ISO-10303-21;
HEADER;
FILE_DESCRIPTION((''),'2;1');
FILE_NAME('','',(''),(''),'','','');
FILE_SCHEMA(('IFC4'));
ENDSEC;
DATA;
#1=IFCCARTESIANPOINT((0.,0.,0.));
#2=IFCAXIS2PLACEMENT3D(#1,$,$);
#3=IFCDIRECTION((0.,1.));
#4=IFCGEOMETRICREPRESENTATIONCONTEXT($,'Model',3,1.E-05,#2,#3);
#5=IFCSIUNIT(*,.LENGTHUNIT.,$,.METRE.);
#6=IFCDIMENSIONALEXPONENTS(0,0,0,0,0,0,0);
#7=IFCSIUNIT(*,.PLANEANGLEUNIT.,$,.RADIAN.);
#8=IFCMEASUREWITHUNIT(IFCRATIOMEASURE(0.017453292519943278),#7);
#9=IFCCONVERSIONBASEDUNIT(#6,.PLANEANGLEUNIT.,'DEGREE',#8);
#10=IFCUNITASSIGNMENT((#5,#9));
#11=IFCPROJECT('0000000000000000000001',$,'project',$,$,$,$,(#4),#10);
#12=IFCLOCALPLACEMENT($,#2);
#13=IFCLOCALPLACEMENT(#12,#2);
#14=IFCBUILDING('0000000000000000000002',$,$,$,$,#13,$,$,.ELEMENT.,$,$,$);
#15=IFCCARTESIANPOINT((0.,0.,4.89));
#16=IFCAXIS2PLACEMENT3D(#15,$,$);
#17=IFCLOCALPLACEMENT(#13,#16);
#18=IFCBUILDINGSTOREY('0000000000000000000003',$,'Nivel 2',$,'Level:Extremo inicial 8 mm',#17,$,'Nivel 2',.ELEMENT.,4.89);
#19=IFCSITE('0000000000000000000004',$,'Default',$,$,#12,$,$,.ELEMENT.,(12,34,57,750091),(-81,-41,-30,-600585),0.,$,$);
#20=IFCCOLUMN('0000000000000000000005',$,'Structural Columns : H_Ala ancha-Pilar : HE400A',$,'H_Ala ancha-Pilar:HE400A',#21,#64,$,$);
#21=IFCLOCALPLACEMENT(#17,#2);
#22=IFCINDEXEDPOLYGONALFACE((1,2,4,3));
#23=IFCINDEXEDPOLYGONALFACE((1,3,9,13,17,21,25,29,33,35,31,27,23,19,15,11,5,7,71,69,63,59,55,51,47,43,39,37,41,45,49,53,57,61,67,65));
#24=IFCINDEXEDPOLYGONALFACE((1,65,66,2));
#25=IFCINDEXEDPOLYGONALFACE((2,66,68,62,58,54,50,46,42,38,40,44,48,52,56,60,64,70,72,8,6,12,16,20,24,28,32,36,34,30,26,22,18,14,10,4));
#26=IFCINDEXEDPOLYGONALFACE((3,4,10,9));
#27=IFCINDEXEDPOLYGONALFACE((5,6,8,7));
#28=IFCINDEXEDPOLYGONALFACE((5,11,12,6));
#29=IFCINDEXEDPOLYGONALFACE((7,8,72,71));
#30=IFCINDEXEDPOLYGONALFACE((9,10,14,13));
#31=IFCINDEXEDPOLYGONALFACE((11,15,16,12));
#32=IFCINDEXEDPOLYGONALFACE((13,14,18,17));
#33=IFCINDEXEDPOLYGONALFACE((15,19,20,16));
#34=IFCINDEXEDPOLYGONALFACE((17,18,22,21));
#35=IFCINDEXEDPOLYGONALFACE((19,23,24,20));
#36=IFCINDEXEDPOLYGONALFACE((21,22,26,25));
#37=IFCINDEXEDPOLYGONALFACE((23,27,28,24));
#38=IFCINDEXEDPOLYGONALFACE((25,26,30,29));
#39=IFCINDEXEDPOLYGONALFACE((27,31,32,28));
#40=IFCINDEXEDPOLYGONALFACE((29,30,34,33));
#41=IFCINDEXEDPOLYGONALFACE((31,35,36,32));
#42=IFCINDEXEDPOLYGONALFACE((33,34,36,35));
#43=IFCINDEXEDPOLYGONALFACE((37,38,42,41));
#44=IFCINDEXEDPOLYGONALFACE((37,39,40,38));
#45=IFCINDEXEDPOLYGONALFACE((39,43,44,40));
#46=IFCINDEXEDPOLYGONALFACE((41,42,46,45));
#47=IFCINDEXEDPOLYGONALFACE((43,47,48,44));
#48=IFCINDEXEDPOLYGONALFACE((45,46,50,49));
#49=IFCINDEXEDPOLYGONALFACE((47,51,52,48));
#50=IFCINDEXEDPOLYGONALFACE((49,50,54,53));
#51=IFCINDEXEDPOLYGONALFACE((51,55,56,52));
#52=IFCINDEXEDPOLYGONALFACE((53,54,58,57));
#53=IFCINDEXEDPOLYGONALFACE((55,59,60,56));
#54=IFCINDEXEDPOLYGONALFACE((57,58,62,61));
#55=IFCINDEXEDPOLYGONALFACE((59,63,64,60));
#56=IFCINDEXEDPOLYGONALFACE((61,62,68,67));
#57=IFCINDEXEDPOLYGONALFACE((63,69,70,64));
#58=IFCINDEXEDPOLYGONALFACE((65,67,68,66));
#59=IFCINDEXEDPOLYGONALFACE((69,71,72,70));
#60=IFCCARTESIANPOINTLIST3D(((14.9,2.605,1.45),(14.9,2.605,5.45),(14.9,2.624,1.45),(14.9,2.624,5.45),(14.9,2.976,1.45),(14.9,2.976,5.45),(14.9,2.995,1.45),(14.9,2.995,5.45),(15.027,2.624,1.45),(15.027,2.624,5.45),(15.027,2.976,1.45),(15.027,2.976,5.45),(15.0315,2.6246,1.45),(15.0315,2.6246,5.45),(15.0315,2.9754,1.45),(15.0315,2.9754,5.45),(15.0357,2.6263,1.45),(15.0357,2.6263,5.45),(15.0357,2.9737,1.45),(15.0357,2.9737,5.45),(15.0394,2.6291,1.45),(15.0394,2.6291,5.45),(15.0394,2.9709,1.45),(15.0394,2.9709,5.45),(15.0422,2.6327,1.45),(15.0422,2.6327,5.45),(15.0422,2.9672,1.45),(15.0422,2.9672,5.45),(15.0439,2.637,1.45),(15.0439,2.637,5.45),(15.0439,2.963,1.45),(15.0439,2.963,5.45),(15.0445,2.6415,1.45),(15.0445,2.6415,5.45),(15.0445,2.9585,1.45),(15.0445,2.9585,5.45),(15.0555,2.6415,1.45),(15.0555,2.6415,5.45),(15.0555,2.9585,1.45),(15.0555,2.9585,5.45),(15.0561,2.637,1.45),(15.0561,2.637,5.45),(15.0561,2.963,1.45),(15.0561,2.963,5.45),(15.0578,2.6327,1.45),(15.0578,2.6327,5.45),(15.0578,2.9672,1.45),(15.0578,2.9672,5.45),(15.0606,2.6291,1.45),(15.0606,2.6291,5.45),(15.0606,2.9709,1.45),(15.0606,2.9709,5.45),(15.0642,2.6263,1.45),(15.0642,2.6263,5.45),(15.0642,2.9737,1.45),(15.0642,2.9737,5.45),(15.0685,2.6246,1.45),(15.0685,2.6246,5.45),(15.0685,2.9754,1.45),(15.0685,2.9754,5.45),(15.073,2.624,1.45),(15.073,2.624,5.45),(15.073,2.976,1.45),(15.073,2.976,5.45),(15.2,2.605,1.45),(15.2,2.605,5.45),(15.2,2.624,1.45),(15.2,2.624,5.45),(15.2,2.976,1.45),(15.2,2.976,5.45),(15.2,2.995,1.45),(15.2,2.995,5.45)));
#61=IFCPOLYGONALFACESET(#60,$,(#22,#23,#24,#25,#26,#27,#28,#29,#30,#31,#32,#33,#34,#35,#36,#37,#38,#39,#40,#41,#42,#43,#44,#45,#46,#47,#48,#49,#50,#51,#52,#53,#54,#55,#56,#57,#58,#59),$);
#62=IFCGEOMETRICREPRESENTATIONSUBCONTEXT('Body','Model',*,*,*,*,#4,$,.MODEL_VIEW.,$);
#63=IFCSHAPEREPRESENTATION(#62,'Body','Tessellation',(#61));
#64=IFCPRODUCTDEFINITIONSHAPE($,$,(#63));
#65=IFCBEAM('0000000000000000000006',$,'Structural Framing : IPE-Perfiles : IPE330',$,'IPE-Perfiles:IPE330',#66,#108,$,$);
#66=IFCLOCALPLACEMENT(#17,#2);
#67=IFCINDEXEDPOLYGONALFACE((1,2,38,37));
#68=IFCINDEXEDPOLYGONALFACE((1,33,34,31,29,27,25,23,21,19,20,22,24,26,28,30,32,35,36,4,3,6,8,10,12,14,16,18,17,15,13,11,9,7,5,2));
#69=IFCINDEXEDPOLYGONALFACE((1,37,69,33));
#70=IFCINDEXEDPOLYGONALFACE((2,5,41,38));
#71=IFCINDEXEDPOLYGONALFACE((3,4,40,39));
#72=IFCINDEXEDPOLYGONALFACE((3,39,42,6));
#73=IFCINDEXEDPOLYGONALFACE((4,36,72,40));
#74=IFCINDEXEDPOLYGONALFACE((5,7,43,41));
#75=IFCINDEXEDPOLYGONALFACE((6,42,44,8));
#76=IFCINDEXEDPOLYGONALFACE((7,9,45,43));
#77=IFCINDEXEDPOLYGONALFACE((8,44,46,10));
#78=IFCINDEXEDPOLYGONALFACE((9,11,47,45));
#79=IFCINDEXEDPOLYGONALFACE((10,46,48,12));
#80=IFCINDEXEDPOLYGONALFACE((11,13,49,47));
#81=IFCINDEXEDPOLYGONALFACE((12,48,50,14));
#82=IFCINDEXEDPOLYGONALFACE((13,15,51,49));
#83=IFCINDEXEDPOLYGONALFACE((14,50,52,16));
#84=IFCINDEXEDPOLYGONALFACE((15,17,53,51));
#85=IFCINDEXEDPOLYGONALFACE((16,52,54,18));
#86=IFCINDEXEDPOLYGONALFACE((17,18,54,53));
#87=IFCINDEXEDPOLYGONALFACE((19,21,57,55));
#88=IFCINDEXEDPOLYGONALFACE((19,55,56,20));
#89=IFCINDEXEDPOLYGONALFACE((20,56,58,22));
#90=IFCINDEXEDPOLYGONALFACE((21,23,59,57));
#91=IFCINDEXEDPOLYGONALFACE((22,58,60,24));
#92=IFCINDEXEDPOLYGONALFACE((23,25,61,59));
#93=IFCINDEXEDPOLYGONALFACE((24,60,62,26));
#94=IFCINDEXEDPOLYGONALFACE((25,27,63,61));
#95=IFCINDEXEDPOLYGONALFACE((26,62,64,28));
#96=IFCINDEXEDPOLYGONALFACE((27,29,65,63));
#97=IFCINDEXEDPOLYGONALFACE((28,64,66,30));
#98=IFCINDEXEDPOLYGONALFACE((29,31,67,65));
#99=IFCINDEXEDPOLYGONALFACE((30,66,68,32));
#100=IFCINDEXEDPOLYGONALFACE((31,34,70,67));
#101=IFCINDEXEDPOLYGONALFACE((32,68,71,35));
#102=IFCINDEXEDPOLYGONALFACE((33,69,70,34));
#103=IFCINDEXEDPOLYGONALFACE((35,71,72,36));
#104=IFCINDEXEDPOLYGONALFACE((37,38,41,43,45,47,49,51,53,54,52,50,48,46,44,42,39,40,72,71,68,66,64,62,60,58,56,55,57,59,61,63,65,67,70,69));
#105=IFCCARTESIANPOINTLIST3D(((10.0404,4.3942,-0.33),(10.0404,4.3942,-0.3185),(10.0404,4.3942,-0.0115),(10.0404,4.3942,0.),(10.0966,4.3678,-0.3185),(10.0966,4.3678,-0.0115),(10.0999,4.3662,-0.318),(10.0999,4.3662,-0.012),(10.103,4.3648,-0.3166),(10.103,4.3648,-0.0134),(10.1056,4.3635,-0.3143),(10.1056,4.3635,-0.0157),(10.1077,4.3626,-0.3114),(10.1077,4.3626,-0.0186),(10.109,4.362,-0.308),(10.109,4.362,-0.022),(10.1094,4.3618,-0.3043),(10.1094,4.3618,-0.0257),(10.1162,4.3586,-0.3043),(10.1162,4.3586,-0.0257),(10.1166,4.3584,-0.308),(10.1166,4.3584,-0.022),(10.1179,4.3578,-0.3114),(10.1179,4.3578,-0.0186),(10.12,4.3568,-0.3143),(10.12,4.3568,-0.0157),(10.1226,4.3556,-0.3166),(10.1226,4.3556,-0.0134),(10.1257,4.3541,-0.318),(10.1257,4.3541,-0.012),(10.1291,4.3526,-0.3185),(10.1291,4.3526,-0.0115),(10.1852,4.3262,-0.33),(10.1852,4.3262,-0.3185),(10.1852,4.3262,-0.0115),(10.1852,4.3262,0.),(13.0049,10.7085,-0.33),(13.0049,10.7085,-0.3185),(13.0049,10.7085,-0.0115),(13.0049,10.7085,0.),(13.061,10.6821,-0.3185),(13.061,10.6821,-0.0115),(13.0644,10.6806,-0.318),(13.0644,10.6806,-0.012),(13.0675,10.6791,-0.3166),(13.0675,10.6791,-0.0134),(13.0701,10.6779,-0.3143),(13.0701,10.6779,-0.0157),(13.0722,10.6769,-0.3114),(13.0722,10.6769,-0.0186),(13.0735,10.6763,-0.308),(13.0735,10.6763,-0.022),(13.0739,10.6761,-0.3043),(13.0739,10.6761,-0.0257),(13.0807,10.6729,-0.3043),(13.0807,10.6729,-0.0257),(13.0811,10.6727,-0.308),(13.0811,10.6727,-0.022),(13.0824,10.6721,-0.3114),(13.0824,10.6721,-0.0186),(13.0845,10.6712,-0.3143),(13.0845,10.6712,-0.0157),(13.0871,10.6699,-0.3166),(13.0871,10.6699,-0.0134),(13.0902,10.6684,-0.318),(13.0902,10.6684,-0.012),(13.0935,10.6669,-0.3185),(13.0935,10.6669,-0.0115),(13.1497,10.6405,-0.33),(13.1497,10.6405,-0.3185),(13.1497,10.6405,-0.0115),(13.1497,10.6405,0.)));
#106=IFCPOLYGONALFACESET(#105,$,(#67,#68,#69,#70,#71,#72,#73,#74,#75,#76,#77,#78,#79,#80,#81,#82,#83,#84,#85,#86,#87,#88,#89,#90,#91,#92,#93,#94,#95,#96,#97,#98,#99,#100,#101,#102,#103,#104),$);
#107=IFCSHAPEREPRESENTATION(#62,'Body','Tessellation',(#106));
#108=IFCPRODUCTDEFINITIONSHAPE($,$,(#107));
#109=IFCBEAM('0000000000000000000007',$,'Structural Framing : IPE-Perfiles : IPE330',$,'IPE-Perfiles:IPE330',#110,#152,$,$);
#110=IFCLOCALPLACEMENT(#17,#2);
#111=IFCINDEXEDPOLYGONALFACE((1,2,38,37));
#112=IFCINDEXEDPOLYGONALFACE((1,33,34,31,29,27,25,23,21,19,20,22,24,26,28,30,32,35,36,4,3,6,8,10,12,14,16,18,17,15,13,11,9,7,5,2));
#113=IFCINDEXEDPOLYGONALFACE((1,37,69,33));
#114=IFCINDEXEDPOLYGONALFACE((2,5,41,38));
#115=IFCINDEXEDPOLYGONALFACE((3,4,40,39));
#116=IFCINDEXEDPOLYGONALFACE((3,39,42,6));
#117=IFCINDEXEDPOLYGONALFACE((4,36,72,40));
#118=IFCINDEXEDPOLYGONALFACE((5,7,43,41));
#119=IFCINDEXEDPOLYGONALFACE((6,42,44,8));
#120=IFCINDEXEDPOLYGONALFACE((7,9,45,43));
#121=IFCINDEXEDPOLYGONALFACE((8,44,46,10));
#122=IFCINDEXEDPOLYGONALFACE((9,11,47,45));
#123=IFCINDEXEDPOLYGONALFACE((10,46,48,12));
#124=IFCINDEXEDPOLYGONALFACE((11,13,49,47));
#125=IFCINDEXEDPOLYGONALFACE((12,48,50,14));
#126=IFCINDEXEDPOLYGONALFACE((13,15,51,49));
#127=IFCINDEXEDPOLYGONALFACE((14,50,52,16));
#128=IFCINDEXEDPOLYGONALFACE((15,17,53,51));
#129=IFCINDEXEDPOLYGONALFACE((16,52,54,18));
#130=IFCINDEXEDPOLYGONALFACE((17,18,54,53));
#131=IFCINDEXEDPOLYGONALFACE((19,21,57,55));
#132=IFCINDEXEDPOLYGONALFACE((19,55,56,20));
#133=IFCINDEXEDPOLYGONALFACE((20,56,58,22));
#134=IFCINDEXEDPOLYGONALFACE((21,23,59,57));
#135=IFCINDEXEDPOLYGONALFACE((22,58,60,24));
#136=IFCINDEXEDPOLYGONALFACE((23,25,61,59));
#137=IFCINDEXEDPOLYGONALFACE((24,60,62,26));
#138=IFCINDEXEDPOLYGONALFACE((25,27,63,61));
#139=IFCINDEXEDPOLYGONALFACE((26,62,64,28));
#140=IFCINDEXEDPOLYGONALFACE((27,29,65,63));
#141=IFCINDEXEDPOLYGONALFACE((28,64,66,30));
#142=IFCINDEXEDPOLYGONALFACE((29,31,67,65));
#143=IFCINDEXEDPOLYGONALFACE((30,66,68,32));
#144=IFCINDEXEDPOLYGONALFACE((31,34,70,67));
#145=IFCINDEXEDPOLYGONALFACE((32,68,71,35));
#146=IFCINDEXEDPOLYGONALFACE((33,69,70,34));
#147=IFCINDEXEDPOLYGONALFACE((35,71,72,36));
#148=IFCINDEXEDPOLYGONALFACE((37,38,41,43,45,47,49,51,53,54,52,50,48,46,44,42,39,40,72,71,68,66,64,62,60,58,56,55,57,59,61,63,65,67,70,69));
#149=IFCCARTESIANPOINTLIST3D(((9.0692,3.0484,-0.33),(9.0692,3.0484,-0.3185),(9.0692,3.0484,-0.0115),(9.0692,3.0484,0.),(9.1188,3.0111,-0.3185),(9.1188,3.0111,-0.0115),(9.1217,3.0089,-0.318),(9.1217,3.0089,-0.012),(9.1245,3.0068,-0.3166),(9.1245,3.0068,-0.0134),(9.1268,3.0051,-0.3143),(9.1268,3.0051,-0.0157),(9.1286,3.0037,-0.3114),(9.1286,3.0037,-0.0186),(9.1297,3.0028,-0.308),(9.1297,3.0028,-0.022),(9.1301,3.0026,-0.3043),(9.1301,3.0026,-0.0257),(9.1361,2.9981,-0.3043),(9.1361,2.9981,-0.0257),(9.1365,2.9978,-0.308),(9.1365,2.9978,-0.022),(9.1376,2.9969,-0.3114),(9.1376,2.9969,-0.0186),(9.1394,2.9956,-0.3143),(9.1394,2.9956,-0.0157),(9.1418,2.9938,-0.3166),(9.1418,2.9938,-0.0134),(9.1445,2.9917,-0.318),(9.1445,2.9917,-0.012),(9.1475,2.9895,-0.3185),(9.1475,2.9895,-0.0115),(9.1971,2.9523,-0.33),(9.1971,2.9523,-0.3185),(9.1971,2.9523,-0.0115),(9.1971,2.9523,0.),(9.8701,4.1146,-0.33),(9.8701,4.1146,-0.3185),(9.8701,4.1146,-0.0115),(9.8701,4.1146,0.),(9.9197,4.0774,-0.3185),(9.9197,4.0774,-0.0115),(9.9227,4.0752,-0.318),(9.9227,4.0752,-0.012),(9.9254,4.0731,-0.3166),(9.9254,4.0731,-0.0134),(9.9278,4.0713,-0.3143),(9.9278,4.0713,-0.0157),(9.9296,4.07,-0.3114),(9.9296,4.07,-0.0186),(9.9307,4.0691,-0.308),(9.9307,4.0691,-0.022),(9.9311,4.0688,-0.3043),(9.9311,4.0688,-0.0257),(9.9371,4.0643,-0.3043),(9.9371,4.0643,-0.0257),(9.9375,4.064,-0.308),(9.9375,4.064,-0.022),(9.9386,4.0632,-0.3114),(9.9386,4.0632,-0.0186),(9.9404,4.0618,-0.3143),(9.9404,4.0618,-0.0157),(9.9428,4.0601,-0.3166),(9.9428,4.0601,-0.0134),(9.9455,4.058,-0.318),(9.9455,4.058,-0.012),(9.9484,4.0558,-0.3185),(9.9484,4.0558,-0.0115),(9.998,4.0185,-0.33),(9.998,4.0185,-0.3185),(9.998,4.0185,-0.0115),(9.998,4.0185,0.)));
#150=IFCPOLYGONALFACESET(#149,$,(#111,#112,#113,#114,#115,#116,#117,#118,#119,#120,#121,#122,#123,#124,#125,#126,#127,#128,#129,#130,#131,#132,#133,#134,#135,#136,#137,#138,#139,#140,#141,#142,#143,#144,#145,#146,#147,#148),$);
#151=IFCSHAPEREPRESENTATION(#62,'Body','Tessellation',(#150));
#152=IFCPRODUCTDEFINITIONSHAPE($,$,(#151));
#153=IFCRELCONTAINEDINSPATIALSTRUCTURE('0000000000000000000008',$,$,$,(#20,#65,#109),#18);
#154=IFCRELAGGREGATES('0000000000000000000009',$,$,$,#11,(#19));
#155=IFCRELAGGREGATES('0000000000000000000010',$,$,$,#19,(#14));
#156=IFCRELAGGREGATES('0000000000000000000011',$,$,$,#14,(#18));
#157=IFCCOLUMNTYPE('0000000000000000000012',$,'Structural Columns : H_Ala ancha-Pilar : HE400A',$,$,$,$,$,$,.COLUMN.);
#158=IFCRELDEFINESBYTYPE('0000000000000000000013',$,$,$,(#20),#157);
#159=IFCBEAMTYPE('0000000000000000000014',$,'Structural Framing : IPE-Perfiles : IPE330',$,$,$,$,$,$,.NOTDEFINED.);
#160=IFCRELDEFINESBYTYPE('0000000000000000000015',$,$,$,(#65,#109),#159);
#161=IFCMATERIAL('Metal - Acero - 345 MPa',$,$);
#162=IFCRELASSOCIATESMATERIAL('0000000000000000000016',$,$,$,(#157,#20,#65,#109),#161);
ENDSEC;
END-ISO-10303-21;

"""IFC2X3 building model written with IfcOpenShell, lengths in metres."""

from ifc_helpers import new_model, entity, si_unit, converted_unit, direction, frame, frame_2d, origin, place, context, subcontext, project, spatial, polyline, circle_curve, parameter, trimmed, segment, composite_curve, i_section, outline, extrude, source, transform, mapped, material, type_object, type_shapes, element, save


model = new_model("IFC2X3")

# Units and contexts
model_context = context("Model", 3, precision=1e-05, world=origin(), true_north=direction((0.0, 1.0)))
body_context = subcontext(model_context, "Body", "Model", "MODEL_VIEW")
ifc_project = project(units=[si_unit("LENGTHUNIT", "METRE"), converted_unit("PLANEANGLEUNIT", "DEGREE", entity("IfcRatioMeasure", 0.017453292519943278), si_unit("PLANEANGLEUNIT", "RADIAN"), dimensions=[0, 0, 0, 0, 0, 0, 0])], contexts=[model_context])

# Site, building, storey
site_placement = place(None, origin())
site = spatial("IfcSite", under=ifc_project, at=site_placement, Name="Default", CompositionType="ELEMENT", RefLatitude=(12, 34, 57, 750091), RefLongitude=(-81, -41, -30, -600585), RefElevation=0.0)
building_placement = place(site_placement, origin())
building = spatial("IfcBuilding", under=site, at=building_placement, CompositionType="ELEMENT")
storey_placement = place(building_placement, frame((0.0, 0.0, 4.89)))
storey = spatial("IfcBuildingStorey", under=building, at=storey_placement, Name="Nivel 2", ObjectType="Level:Extremo inicial 8 mm", LongName="Nivel 2", CompositionType="ELEMENT", Elevation=4.89)

# Column
ifc_material_1 = material(Name="Metal - Acero - 345 MPa")
column_type_1 = type_object("IfcColumnType", Name="Structural Columns : H_Ala ancha-Pilar : HE400A", PredefinedType="COLUMN", material=ifc_material_1)
shared_shape_1 = source(origin(), body_context, "Body", "SweptSolid", [
    extrude(outline(composite_curve([segment(polyline([(0.176, -0.15), (0.195, -0.15)]), True, "CONTINUOUS"), segment(polyline([(0.195, -0.15), (0.195, 0.15)]), True, "CONTINUOUS"), segment(polyline([(0.195, 0.15), (0.176, 0.15)]), True, "CONTINUOUS"), segment(polyline([(0.176, 0.15), (0.176, 0.023)]), True, "CONTINUOUS"), segment(trimmed(circle_curve(frame_2d((0.1585, 0.023), x_axis=(1.0, 0.0)), 0.0175), [parameter(270.0)], [parameter(0.0)], True, "PARAMETER"), False, "CONTINUOUS"), segment(polyline([(0.1585, 0.0055), (-0.1585, 0.0055)]), True, "CONTINUOUS"), segment(trimmed(circle_curve(frame_2d((-0.1585, 0.023), x_axis=(0.0, -1.0)), 0.0175), [parameter(270.0)], [parameter(0.0)], True, "PARAMETER"), False, "CONTINUOUS"), segment(polyline([(-0.176, 0.023), (-0.176, 0.15)]), True, "CONTINUOUS"), segment(polyline([(-0.176, 0.15), (-0.195, 0.15)]), True, "CONTINUOUS"), segment(polyline([(-0.195, 0.15), (-0.195, -0.15)]), True, "CONTINUOUS"), segment(polyline([(-0.195, -0.15), (-0.176, -0.15)]), True, "CONTINUOUS"), segment(polyline([(-0.176, -0.15), (-0.176, -0.023)]), True, "CONTINUOUS"), segment(trimmed(circle_curve(frame_2d((-0.1585, -0.023), x_axis=(-1.0, 0.0)), 0.0175), [parameter(270.0)], [parameter(0.0)], True, "PARAMETER"), False, "CONTINUOUS"), segment(polyline([(-0.1585, -0.0055), (0.1585, -0.0055)]), True, "CONTINUOUS"), segment(trimmed(circle_curve(frame_2d((0.1585, -0.023), x_axis=(0.0, 1.0)), 0.0175), [parameter(270.0)], [parameter(0.0)], True, "PARAMETER"), False, "CONTINUOUS"), segment(polyline([(0.176, -0.023), (0.176, -0.15)]), True, "CONTINUOUS")], self_intersect=False)), frame((0.0, 0.0, 6.34), z_axis=(0.0, 0.0, 1.0), x_axis=(0.0, -1.0, 0.0)), (0.0, 0.0, 1.0), 4.0),
])
type_shapes(column_type_1, [shared_shape_1])
column_1_placement = place(storey_placement, frame((15.05, 2.8, -4.89)))
element("IfcColumn", 1, at=column_1_placement, inside=storey, type_object=column_type_1, material=ifc_material_1, Name="Structural Columns : H_Ala ancha-Pilar : HE400A", ObjectType="H_Ala ancha-Pilar:HE400A", context=body_context, shape_type="MappedRepresentation", body=[
    mapped(shared_shape_1, transform((0.0, 0.0, 0.0), scale=1.0)),
])

# Beams
beam_type_1 = type_object("IfcBeamType", Name="Structural Framing : IPE-Perfiles : IPE330", PredefinedType="NOTDEFINED")
beam_1_placement = place(storey_placement, frame((10.0431, 4.2117, 0.0), z_axis=(0.0, 0.0, 1.0), x_axis=(0.42498, 0.905203, 0.0)))
element("IfcBeam", 2, at=beam_1_placement, inside=storey, type_object=beam_type_1, material=ifc_material_1, Name="Structural Framing : IPE-Perfiles : IPE330", ObjectType="IPE-Perfiles:IPE330", context=body_context, shape_type="SweptSolid", body=[
    extrude(i_section(OverallWidth=0.16, OverallDepth=0.33, WebThickness=0.0075, FlangeThickness=0.0115, FilletRadius=0.0142, at=frame_2d((0.0, 0.0), x_axis=(0.0, 1.0))), frame((0.164, 0.0, -0.165), z_axis=(1.0, 0.0, 0.0), x_axis=(0.0, 0.0, -1.0)), (0.0, 0.0, 1.0), 6.9756),
])
beam_2_placement = place(storey_placement, frame((8.9827, 2.8, 0.0), z_axis=(0.0, 0.0, 1.0), x_axis=(0.600599, 0.799551, 0.0)))
element("IfcBeam", 3, at=beam_2_placement, inside=storey, type_object=beam_type_1, material=ifc_material_1, Name="Structural Framing : IPE-Perfiles : IPE330", ObjectType="IPE-Perfiles:IPE330", context=body_context, shape_type="SweptSolid", body=[
    extrude(i_section(OverallWidth=0.16, OverallDepth=0.33, WebThickness=0.0075, FlangeThickness=0.0115, FilletRadius=0.0142, at=frame_2d((0.0, 0.0), x_axis=(0.0, 1.0))), frame((0.2505, 0.0, -0.165), z_axis=(1.0, 0.0, 0.0), x_axis=(0.0, 0.0, -1.0)), (0.0, 0.0, 1.0), 1.3336),
])

save(model, "model.ifc")
